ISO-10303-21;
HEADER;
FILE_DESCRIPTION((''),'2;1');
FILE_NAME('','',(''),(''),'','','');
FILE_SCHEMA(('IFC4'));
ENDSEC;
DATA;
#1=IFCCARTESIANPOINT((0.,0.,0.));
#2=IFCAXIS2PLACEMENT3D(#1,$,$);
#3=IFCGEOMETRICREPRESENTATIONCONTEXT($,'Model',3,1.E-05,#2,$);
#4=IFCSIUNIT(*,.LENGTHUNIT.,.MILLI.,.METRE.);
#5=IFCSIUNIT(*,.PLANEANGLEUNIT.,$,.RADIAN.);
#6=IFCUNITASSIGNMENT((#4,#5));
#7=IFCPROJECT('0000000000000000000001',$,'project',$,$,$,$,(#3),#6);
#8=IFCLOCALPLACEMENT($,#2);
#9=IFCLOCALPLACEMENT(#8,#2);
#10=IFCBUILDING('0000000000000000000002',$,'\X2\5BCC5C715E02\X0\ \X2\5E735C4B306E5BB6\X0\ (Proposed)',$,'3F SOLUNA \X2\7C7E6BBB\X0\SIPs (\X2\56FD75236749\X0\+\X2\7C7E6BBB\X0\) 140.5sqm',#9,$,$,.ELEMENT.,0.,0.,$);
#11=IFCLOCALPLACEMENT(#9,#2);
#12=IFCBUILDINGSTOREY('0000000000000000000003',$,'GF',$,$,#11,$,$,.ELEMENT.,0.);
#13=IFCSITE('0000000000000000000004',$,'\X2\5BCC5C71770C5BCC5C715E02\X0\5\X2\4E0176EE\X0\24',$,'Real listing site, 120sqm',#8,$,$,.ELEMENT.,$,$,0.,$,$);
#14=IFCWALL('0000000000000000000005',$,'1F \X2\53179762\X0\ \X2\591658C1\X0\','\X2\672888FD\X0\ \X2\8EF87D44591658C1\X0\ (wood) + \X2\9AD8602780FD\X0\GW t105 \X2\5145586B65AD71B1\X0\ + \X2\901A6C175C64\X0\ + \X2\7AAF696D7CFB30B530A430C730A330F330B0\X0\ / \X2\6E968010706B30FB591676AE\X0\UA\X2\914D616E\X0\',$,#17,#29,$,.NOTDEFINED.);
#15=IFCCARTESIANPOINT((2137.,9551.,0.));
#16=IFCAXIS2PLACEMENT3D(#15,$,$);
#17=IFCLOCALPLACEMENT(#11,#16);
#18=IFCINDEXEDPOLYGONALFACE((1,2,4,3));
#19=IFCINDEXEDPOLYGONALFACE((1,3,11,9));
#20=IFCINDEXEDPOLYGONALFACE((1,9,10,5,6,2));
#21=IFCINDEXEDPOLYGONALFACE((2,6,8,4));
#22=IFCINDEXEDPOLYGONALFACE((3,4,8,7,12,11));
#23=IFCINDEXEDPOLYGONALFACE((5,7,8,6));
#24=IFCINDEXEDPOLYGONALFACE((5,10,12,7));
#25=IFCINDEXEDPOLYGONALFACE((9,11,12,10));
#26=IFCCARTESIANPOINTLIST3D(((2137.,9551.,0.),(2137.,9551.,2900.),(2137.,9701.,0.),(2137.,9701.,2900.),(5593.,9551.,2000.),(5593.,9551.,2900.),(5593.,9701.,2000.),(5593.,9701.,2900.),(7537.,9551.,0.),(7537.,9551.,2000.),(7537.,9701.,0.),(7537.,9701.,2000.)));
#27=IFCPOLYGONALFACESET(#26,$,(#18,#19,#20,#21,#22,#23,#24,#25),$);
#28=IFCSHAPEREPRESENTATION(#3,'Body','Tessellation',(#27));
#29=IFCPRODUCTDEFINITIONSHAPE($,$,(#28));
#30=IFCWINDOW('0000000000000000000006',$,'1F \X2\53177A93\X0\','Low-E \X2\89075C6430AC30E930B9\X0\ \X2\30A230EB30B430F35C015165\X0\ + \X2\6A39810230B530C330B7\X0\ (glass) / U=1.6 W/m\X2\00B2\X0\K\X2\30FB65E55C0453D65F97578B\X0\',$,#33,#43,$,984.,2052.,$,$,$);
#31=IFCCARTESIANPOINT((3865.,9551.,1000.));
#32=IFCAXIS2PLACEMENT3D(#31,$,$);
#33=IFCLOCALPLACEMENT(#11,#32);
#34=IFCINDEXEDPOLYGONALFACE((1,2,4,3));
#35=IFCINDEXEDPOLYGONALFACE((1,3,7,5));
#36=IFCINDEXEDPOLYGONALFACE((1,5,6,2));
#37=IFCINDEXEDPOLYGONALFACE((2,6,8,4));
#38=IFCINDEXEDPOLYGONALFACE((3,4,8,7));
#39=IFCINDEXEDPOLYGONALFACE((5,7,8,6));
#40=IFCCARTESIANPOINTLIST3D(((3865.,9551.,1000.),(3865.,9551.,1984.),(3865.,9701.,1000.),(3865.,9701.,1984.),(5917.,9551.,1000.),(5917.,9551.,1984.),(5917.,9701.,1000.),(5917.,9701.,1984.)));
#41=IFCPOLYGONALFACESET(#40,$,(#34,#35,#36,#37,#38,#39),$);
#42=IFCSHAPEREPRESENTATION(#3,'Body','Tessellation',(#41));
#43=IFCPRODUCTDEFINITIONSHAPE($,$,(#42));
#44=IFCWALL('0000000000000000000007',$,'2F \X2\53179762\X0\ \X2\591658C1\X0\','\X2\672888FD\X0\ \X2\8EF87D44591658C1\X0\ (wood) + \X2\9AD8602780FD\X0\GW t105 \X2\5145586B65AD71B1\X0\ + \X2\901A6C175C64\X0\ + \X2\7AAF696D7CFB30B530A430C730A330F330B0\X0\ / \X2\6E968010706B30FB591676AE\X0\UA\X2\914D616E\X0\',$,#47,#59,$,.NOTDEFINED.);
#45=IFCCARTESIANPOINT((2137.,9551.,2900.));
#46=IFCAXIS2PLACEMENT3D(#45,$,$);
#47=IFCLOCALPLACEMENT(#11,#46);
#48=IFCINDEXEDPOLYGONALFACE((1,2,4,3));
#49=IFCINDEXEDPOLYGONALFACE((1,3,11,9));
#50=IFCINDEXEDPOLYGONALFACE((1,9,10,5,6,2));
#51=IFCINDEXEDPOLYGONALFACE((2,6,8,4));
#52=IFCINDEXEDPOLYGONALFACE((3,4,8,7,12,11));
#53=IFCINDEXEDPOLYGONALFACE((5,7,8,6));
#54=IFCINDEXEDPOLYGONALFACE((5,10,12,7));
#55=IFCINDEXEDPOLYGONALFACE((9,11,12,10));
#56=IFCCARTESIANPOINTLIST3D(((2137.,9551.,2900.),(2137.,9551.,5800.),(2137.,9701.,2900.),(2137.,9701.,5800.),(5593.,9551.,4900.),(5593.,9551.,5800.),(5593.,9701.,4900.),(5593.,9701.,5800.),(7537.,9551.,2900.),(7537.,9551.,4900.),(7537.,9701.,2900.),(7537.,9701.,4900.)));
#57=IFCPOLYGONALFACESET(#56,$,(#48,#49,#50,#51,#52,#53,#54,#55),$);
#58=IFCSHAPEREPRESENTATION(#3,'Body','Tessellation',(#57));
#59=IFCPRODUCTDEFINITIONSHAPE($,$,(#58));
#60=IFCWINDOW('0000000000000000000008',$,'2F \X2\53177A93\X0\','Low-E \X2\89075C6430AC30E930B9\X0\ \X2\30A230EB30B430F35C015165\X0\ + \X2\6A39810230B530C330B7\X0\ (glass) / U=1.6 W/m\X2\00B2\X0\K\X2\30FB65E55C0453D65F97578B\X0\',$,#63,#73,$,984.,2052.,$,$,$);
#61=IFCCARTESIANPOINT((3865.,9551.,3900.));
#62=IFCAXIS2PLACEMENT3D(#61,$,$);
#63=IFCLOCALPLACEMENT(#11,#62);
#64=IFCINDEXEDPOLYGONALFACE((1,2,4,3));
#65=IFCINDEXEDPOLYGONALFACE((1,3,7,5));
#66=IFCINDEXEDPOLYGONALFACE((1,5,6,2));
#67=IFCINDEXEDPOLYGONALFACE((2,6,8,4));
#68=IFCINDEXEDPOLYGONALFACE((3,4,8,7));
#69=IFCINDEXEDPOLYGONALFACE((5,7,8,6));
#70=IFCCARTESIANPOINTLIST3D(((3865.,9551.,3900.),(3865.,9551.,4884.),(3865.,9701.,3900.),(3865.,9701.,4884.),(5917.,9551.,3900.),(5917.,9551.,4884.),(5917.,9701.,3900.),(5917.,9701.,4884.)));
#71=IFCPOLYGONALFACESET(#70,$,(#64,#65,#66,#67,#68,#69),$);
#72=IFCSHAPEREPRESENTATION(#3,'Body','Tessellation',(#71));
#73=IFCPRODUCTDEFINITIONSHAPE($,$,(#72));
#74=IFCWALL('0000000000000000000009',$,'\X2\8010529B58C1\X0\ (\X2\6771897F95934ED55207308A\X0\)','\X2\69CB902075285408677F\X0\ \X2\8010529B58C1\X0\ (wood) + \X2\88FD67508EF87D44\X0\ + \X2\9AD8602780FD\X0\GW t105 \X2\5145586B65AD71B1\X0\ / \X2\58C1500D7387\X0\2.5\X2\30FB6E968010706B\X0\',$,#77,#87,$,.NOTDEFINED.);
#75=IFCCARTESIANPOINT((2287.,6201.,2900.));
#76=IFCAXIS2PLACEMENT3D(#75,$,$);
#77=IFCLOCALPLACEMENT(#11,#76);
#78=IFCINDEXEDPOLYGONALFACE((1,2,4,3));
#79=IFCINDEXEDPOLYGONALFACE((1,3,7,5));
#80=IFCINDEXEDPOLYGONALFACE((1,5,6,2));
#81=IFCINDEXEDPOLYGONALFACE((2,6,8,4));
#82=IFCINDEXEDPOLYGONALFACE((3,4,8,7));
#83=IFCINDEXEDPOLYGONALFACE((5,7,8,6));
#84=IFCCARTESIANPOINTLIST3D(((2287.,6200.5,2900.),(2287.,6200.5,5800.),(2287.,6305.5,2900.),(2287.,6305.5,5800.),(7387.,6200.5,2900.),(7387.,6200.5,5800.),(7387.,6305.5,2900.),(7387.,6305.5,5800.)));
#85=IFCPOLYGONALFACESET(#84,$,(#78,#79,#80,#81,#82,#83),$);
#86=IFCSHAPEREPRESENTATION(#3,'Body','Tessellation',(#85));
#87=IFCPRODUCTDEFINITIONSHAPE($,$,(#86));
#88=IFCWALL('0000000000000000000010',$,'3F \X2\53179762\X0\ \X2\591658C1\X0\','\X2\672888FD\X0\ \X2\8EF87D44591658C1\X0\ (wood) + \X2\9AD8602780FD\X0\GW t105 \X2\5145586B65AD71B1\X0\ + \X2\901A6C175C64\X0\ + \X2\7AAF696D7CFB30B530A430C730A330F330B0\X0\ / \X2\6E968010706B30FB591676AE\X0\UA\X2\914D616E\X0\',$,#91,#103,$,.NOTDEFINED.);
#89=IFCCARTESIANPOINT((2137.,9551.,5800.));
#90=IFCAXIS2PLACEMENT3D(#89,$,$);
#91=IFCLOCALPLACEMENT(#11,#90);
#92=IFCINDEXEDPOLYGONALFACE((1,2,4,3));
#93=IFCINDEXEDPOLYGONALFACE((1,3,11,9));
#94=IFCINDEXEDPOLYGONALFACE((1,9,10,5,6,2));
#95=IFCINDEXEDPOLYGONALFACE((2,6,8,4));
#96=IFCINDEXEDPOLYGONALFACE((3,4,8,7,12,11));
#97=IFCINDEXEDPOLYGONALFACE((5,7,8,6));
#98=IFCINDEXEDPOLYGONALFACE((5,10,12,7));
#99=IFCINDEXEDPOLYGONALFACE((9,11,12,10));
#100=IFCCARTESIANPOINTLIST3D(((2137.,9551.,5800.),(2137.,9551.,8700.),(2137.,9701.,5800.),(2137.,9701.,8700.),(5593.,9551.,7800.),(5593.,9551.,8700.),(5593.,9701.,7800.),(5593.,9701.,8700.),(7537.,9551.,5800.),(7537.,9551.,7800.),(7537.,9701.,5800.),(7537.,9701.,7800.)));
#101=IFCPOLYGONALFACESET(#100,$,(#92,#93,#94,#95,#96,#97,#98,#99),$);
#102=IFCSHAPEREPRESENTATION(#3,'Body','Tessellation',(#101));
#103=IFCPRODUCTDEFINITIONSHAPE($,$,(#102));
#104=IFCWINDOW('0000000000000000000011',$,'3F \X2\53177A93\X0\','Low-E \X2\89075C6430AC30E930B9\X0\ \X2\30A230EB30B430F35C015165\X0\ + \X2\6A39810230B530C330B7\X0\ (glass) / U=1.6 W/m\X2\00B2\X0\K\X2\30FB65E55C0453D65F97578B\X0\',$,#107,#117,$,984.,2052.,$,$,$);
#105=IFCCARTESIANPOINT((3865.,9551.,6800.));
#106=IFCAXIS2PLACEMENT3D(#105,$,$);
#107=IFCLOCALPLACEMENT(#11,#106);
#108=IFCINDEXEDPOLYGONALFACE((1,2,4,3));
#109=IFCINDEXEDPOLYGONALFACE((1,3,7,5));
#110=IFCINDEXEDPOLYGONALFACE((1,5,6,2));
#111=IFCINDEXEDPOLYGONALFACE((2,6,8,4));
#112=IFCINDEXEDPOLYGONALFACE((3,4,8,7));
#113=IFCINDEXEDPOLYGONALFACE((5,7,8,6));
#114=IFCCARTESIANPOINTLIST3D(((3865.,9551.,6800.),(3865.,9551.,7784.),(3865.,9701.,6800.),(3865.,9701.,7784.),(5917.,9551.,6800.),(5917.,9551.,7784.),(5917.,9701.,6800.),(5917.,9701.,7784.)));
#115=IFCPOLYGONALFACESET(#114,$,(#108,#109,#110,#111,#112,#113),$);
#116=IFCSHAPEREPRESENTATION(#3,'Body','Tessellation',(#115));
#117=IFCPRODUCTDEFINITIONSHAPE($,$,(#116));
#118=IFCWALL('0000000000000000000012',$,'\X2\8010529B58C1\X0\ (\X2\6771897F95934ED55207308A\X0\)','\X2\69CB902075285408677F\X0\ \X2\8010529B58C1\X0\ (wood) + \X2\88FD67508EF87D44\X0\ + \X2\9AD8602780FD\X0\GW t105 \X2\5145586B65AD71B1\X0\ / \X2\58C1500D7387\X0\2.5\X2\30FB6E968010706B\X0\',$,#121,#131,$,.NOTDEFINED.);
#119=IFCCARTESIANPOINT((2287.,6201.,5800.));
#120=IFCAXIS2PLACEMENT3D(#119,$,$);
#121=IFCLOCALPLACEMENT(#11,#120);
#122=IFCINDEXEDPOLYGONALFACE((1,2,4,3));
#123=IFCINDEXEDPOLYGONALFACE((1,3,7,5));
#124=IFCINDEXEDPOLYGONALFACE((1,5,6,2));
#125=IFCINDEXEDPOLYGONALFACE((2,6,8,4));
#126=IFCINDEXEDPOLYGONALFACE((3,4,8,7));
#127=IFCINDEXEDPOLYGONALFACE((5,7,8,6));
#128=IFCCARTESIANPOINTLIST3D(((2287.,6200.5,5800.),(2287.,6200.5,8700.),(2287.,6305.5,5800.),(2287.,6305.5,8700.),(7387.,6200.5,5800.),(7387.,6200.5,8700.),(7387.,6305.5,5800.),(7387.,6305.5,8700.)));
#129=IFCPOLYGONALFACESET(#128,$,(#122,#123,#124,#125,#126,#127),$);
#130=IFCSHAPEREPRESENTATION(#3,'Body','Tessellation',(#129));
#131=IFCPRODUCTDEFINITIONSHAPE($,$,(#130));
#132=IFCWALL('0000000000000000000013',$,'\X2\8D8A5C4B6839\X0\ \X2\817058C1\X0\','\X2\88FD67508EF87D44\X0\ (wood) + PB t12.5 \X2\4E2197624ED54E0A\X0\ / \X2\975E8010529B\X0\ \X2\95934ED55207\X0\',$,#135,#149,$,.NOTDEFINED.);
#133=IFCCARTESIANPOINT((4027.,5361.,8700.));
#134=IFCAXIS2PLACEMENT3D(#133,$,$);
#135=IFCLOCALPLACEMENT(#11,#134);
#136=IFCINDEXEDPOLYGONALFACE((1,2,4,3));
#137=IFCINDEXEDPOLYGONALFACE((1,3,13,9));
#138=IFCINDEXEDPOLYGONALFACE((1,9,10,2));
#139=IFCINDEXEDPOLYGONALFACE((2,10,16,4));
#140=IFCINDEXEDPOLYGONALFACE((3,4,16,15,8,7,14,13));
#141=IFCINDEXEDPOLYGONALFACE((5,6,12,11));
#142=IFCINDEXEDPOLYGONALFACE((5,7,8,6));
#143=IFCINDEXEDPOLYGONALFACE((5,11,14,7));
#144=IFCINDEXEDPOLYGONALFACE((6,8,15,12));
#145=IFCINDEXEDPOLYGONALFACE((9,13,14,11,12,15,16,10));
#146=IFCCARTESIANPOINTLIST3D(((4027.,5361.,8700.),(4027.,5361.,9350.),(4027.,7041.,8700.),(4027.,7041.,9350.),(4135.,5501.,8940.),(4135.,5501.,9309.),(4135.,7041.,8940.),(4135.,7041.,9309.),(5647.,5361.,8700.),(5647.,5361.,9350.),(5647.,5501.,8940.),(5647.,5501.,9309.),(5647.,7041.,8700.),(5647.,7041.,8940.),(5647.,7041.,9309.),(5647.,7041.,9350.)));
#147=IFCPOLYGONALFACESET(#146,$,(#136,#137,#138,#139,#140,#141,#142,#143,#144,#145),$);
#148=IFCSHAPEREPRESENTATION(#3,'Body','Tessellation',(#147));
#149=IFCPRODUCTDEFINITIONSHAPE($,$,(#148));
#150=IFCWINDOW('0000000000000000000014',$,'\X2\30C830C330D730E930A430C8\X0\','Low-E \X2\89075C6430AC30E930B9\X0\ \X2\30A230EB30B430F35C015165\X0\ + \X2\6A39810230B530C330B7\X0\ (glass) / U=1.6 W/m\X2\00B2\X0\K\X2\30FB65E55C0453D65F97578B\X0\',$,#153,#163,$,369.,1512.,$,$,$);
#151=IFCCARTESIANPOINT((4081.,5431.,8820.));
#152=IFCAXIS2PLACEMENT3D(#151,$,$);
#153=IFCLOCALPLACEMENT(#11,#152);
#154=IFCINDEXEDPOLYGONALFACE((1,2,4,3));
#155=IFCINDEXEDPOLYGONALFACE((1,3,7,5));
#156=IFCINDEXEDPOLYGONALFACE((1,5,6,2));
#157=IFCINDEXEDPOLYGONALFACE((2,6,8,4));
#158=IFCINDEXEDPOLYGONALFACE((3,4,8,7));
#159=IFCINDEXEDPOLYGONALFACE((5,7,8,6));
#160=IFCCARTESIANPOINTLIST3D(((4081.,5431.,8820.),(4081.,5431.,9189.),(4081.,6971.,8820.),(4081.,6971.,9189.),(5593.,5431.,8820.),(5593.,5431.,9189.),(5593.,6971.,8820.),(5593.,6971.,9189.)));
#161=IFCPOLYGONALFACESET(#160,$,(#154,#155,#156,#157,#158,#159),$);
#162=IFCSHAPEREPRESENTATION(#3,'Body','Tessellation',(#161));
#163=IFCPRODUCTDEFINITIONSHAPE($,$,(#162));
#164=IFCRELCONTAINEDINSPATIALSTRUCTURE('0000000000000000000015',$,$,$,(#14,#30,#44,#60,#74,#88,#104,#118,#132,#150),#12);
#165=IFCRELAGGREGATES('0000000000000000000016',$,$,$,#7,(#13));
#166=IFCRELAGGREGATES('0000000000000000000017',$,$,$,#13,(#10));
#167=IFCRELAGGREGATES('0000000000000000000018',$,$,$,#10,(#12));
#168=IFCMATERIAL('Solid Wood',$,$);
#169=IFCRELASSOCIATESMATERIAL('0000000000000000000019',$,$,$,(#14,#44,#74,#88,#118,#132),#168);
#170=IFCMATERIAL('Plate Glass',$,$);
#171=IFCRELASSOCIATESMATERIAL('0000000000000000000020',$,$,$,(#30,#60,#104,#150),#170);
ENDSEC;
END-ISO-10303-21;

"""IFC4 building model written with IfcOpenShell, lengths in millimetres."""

from ifc_helpers import new_model, si_unit, frame, frame_2d, origin, place, context, project, spatial, rectangle, extrude, material, element, fill, save


model = new_model("IFC4")

# Units and contexts
model_context = context("Model", 3, precision=1e-05, world=origin())
ifc_project = project(units=[si_unit("LENGTHUNIT", "METRE", prefix="MILLI"), si_unit("PLANEANGLEUNIT", "RADIAN")], contexts=[model_context])

# Site, building, storey
site_placement = place(None, origin())
site = spatial("IfcSite", under=ifc_project, at=site_placement, Name="富山県富山市5丁目24", ObjectType="Real listing site, 120sqm", CompositionType="ELEMENT", RefElevation=0.0)
building_placement = place(site_placement, origin())
building = spatial("IfcBuilding", under=site, at=building_placement, Name="富山市 平屋の家 (Proposed)", ObjectType="3F SOLUNA 籾殻SIPs (国産杉+籾殻) 140.5sqm", CompositionType="ELEMENT", ElevationOfRefHeight=0.0, ElevationOfTerrain=0.0)
storey_placement = place(building_placement, origin())
storey = spatial("IfcBuildingStorey", under=building, at=storey_placement, Name="GF", CompositionType="ELEMENT", Elevation=0.0)

# Wall, opening, window
ifc_material_1 = material(Name="Solid Wood")
wall_1_placement = place(storey_placement, frame((2137.0, 9551.0, 0.0)))
wall_1 = element("IfcWall", 1, at=wall_1_placement, inside=storey, material=ifc_material_1, Name="1F 北面 外壁", Description="木製 軸組外壁 (wood) + 高性能GW t105 充填断熱 + 通気層 + 窯業系サイディング / 準耐火・外皮UA配慮", PredefinedType="NOTDEFINED", context=model_context, shape_type="SweptSolid", body=[
    extrude(rectangle(XDim=5400.0, YDim=150.0, at=frame_2d((2700.0, 75.0))), frame((2137.0, 9551.0, 0.0)), (0.0, 0.0, 1.0), 2900.0),
])
opening_1_placement = place(storey_placement, frame((3865.0, 9551.0, 1000.0)))
opening_1 = element("IfcOpeningElement", 2, at=opening_1_placement, cuts=wall_1, PredefinedType="NOTDEFINED", context=model_context, shape_type="SweptSolid", body=[
    extrude(rectangle(XDim=2052.0, YDim=150.0, at=frame_2d((1026.0, 75.0))), frame((3865.0, 9551.0, 1000.0)), (0.0, 0.0, 1.0), 984.0),
])
ifc_material_2 = material(Name="Plate Glass")
window_1_placement = place(storey_placement, frame((3865.0, 9551.0, 1000.0)))
window_1 = element("IfcWindow", 3, at=window_1_placement, inside=storey, material=ifc_material_2, Name="1F 北窓", Description="Low-E 複層ガラス アルゴン封入 + 樹脂サッシ (glass) / U=1.6 W/m²K・日射取得型", OverallHeight=984.0, OverallWidth=2052.0, context=model_context, shape_type="SweptSolid", body=[
    extrude(rectangle(XDim=2052.0, YDim=150.0, at=frame_2d((1026.0, 75.0))), frame((3865.0, 9551.0, 1000.0)), (0.0, 0.0, 1.0), 984.0),
])
fill(opening_1, window_1)

# Wall, opening, window
wall_2_placement = place(storey_placement, frame((2137.0, 9551.0, 2900.0)))
wall_2 = element("IfcWall", 4, at=wall_2_placement, inside=storey, material=ifc_material_1, Name="2F 北面 外壁", Description="木製 軸組外壁 (wood) + 高性能GW t105 充填断熱 + 通気層 + 窯業系サイディング / 準耐火・外皮UA配慮", PredefinedType="NOTDEFINED", context=model_context, shape_type="SweptSolid", body=[
    extrude(rectangle(XDim=5400.0, YDim=150.0, at=frame_2d((2700.0, 75.0))), frame((2137.0, 9551.0, 2900.0)), (0.0, 0.0, 1.0), 2900.0),
])
opening_2_placement = place(storey_placement, frame((3865.0, 9551.0, 3900.0)))
opening_2 = element("IfcOpeningElement", 5, at=opening_2_placement, cuts=wall_2, PredefinedType="NOTDEFINED", context=model_context, shape_type="SweptSolid", body=[
    extrude(rectangle(XDim=2052.0, YDim=150.0, at=frame_2d((1026.0, 75.0))), frame((3865.0, 9551.0, 3900.0)), (0.0, 0.0, 1.0), 984.0),
])
window_2_placement = place(storey_placement, frame((3865.0, 9551.0, 3900.0)))
window_2 = element("IfcWindow", 6, at=window_2_placement, inside=storey, material=ifc_material_2, Name="2F 北窓", Description="Low-E 複層ガラス アルゴン封入 + 樹脂サッシ (glass) / U=1.6 W/m²K・日射取得型", OverallHeight=984.0, OverallWidth=2052.0, context=model_context, shape_type="SweptSolid", body=[
    extrude(rectangle(XDim=2052.0, YDim=150.0, at=frame_2d((1026.0, 75.0))), frame((3865.0, 9551.0, 3900.0)), (0.0, 0.0, 1.0), 984.0),
])
fill(opening_2, window_2)

# Wall
wall_3_placement = place(storey_placement, frame((2287.0, 6201.0, 2900.0)))
element("IfcWall", 7, at=wall_3_placement, inside=storey, material=ifc_material_1, Name="耐力壁 (東西間仕切り)", Description="構造用合板 耐力壁 (wood) + 製材軸組 + 高性能GW t105 充填断熱 / 壁倍率2.5・準耐火", PredefinedType="NOTDEFINED", context=model_context, shape_type="SweptSolid", body=[
    extrude(rectangle(XDim=5100.0, YDim=105.0, at=frame_2d((2550.0, 52.0))), frame((2287.0, 6201.0, 2900.0)), (0.0, 0.0, 1.0), 2900.0),
])

# Wall, opening, window
wall_4_placement = place(storey_placement, frame((2137.0, 9551.0, 5800.0)))
wall_4 = element("IfcWall", 8, at=wall_4_placement, inside=storey, material=ifc_material_1, Name="3F 北面 外壁", Description="木製 軸組外壁 (wood) + 高性能GW t105 充填断熱 + 通気層 + 窯業系サイディング / 準耐火・外皮UA配慮", PredefinedType="NOTDEFINED", context=model_context, shape_type="SweptSolid", body=[
    extrude(rectangle(XDim=5400.0, YDim=150.0, at=frame_2d((2700.0, 75.0))), frame((2137.0, 9551.0, 5800.0)), (0.0, 0.0, 1.0), 2900.0),
])
opening_3_placement = place(storey_placement, frame((3865.0, 9551.0, 6800.0)))
opening_3 = element("IfcOpeningElement", 9, at=opening_3_placement, cuts=wall_4, PredefinedType="NOTDEFINED", context=model_context, shape_type="SweptSolid", body=[
    extrude(rectangle(XDim=2052.0, YDim=150.0, at=frame_2d((1026.0, 75.0))), frame((3865.0, 9551.0, 6800.0)), (0.0, 0.0, 1.0), 984.0),
])
window_3_placement = place(storey_placement, frame((3865.0, 9551.0, 6800.0)))
window_3 = element("IfcWindow", 10, at=window_3_placement, inside=storey, material=ifc_material_2, Name="3F 北窓", Description="Low-E 複層ガラス アルゴン封入 + 樹脂サッシ (glass) / U=1.6 W/m²K・日射取得型", OverallHeight=984.0, OverallWidth=2052.0, context=model_context, shape_type="SweptSolid", body=[
    extrude(rectangle(XDim=2052.0, YDim=150.0, at=frame_2d((1026.0, 75.0))), frame((3865.0, 9551.0, 6800.0)), (0.0, 0.0, 1.0), 984.0),
])
fill(opening_3, window_3)

# Wall
wall_5_placement = place(storey_placement, frame((2287.0, 6201.0, 5800.0)))
element("IfcWall", 11, at=wall_5_placement, inside=storey, material=ifc_material_1, Name="耐力壁 (東西間仕切り)", Description="構造用合板 耐力壁 (wood) + 製材軸組 + 高性能GW t105 充填断熱 / 壁倍率2.5・準耐火", PredefinedType="NOTDEFINED", context=model_context, shape_type="SweptSolid", body=[
    extrude(rectangle(XDim=5100.0, YDim=105.0, at=frame_2d((2550.0, 52.0))), frame((2287.0, 6201.0, 5800.0)), (0.0, 0.0, 1.0), 2900.0),
])

# Wall, opening, window
wall_6_placement = place(storey_placement, frame((4027.0, 5361.0, 8700.0)))
wall_6 = element("IfcWall", 12, at=wall_6_placement, inside=storey, material=ifc_material_1, Name="越屋根 腰壁", Description="製材軸組 (wood) + PB t12.5 両面仕上 / 非耐力 間仕切", PredefinedType="NOTDEFINED", context=model_context, shape_type="SweptSolid", body=[
    extrude(rectangle(XDim=1620.0, YDim=1680.0, at=frame_2d((810.0, 840.0))), frame((4027.0, 5361.0, 8700.0)), (0.0, 0.0, 1.0), 650.0),
])
opening_4_placement = place(storey_placement, frame((4081.0, 5431.0, 8820.0)))
opening_4 = element("IfcOpeningElement", 13, at=opening_4_placement, cuts=wall_6, PredefinedType="NOTDEFINED", context=model_context, shape_type="SweptSolid", body=[
    extrude(rectangle(XDim=1512.0, YDim=1540.0, at=frame_2d((756.0, 770.0))), frame((4081.0, 5431.0, 8820.0)), (0.0, 0.0, 1.0), 369.0),
])
window_4_placement = place(storey_placement, frame((4081.0, 5431.0, 8820.0)))
window_4 = element("IfcWindow", 14, at=window_4_placement, inside=storey, material=ifc_material_2, Name="トップライト", Description="Low-E 複層ガラス アルゴン封入 + 樹脂サッシ (glass) / U=1.6 W/m²K・日射取得型", OverallHeight=369.0, OverallWidth=1512.0, context=model_context, shape_type="SweptSolid", body=[
    extrude(rectangle(XDim=1512.0, YDim=1540.0, at=frame_2d((756.0, 770.0))), frame((4081.0, 5431.0, 8820.0)), (0.0, 0.0, 1.0), 369.0),
])
fill(opening_4, window_4)

save(model, "model.ifc")
